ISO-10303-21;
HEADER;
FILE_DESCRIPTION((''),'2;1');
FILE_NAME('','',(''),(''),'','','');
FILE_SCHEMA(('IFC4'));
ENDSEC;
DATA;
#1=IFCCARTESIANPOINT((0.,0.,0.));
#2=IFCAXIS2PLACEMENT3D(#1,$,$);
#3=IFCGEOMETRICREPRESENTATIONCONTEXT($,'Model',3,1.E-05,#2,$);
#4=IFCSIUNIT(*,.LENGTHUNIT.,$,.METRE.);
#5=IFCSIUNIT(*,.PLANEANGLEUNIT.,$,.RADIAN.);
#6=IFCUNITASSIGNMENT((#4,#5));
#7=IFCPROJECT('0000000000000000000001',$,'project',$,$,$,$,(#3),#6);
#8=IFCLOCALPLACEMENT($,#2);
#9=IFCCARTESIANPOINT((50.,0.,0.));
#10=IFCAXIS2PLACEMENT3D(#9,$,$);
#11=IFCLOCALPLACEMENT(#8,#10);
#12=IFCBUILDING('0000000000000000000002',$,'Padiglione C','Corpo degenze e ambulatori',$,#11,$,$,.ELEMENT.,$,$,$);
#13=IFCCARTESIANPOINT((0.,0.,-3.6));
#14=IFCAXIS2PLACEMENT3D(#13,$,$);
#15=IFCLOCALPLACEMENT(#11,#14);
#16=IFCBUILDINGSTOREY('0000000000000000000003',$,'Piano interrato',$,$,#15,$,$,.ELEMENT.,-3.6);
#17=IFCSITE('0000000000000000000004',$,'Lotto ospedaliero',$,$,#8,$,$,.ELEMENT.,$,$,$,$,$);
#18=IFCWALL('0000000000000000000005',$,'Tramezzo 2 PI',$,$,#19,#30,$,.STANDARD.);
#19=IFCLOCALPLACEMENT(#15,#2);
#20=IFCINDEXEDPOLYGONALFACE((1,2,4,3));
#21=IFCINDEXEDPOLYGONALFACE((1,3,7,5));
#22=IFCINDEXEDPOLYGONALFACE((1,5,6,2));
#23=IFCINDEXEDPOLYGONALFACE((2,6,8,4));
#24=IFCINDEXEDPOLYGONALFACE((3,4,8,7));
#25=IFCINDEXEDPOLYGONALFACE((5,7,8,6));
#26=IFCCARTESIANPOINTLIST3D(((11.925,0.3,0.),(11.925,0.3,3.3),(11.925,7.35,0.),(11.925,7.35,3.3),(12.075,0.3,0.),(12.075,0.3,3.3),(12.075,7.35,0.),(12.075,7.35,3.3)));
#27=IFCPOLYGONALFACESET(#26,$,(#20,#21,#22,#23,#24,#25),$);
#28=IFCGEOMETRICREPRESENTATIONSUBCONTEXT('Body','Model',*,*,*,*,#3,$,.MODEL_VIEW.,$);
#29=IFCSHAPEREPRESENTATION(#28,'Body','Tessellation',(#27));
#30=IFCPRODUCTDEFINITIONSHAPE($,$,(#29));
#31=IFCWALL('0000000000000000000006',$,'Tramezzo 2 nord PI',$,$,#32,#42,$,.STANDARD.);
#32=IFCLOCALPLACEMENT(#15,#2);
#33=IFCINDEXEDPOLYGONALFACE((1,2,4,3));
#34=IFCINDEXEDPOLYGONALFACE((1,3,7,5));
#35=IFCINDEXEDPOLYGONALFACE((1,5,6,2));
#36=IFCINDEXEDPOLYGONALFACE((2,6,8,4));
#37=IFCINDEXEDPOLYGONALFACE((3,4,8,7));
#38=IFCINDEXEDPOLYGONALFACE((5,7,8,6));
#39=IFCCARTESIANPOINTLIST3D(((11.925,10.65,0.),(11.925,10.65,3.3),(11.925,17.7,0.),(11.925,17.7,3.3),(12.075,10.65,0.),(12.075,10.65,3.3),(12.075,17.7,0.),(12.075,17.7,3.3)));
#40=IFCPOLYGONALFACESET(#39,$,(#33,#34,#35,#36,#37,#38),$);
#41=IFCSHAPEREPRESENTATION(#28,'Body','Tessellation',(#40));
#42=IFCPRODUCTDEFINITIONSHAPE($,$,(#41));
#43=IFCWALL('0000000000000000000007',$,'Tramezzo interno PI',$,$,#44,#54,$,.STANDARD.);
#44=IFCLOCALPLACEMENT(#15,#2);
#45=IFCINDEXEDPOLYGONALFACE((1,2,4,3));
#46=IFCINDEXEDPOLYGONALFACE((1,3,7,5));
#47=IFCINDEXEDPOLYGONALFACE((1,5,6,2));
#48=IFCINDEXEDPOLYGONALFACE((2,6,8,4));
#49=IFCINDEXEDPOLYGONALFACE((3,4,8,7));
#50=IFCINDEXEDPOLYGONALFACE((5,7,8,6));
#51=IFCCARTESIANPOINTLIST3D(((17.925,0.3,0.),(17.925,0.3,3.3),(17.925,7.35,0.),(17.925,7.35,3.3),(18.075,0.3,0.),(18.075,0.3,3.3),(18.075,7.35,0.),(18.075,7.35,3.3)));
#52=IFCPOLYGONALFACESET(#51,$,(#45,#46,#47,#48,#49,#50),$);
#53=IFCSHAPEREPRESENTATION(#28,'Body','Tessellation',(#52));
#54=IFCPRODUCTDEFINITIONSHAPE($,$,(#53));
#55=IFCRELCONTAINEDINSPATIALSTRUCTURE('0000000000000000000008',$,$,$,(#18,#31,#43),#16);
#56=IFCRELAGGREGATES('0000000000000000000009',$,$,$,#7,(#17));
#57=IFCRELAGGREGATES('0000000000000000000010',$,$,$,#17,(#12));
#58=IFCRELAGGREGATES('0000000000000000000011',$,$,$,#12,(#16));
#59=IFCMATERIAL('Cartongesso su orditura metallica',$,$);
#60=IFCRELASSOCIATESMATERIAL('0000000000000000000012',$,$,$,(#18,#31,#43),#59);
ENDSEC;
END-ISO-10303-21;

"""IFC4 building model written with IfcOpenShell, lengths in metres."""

from ifc_helpers import new_model, si_unit, frame, frame_2d, origin, place, context, subcontext, project, spatial, rectangle, extrude, material, element, save


model = new_model("IFC4")

# Units and contexts
model_context = context("Model", 3, precision=1e-05, world=origin())
body_context = subcontext(model_context, "Body", "Model", "MODEL_VIEW")
ifc_project = project(units=[si_unit("LENGTHUNIT", "METRE"), si_unit("PLANEANGLEUNIT", "RADIAN")], contexts=[model_context])

# Site, building, storey
site_placement = place(None, origin())
site = spatial("IfcSite", under=ifc_project, at=site_placement, Name="Lotto ospedaliero", CompositionType="ELEMENT")
building_placement = place(site_placement, frame((50.0, 0.0, 0.0)))
building = spatial("IfcBuilding", under=site, at=building_placement, Name="Padiglione C", Description="Corpo degenze e ambulatori", CompositionType="ELEMENT")
storey_placement = place(building_placement, frame((0.0, 0.0, -3.6)))
storey = spatial("IfcBuildingStorey", under=building, at=storey_placement, Name="Piano interrato", CompositionType="ELEMENT", Elevation=-3.6)

# Walls
ifc_material_1 = material(Name="Cartongesso su orditura metallica")
for number, where, name in (
    (1, (11.925, 0.3, 0.0), "Tramezzo 2 PI"),
    (2, (11.925, 10.65, 0.0), "Tramezzo 2 nord PI"),
    (3, (17.925, 0.3, 0.0), "Tramezzo interno PI"),
):
    element("IfcWall", number, at=place(storey_placement, frame(where)), inside=storey, material=ifc_material_1, Name=name, PredefinedType="STANDARD", context=body_context, shape_type="SweptSolid", body=[
        extrude(rectangle(XDim=0.15, YDim=7.05, at=frame_2d((0.075, 3.525))), origin(), (0.0, 0.0, 1.0), 3.3),
    ])

save(model, "model.ifc")
